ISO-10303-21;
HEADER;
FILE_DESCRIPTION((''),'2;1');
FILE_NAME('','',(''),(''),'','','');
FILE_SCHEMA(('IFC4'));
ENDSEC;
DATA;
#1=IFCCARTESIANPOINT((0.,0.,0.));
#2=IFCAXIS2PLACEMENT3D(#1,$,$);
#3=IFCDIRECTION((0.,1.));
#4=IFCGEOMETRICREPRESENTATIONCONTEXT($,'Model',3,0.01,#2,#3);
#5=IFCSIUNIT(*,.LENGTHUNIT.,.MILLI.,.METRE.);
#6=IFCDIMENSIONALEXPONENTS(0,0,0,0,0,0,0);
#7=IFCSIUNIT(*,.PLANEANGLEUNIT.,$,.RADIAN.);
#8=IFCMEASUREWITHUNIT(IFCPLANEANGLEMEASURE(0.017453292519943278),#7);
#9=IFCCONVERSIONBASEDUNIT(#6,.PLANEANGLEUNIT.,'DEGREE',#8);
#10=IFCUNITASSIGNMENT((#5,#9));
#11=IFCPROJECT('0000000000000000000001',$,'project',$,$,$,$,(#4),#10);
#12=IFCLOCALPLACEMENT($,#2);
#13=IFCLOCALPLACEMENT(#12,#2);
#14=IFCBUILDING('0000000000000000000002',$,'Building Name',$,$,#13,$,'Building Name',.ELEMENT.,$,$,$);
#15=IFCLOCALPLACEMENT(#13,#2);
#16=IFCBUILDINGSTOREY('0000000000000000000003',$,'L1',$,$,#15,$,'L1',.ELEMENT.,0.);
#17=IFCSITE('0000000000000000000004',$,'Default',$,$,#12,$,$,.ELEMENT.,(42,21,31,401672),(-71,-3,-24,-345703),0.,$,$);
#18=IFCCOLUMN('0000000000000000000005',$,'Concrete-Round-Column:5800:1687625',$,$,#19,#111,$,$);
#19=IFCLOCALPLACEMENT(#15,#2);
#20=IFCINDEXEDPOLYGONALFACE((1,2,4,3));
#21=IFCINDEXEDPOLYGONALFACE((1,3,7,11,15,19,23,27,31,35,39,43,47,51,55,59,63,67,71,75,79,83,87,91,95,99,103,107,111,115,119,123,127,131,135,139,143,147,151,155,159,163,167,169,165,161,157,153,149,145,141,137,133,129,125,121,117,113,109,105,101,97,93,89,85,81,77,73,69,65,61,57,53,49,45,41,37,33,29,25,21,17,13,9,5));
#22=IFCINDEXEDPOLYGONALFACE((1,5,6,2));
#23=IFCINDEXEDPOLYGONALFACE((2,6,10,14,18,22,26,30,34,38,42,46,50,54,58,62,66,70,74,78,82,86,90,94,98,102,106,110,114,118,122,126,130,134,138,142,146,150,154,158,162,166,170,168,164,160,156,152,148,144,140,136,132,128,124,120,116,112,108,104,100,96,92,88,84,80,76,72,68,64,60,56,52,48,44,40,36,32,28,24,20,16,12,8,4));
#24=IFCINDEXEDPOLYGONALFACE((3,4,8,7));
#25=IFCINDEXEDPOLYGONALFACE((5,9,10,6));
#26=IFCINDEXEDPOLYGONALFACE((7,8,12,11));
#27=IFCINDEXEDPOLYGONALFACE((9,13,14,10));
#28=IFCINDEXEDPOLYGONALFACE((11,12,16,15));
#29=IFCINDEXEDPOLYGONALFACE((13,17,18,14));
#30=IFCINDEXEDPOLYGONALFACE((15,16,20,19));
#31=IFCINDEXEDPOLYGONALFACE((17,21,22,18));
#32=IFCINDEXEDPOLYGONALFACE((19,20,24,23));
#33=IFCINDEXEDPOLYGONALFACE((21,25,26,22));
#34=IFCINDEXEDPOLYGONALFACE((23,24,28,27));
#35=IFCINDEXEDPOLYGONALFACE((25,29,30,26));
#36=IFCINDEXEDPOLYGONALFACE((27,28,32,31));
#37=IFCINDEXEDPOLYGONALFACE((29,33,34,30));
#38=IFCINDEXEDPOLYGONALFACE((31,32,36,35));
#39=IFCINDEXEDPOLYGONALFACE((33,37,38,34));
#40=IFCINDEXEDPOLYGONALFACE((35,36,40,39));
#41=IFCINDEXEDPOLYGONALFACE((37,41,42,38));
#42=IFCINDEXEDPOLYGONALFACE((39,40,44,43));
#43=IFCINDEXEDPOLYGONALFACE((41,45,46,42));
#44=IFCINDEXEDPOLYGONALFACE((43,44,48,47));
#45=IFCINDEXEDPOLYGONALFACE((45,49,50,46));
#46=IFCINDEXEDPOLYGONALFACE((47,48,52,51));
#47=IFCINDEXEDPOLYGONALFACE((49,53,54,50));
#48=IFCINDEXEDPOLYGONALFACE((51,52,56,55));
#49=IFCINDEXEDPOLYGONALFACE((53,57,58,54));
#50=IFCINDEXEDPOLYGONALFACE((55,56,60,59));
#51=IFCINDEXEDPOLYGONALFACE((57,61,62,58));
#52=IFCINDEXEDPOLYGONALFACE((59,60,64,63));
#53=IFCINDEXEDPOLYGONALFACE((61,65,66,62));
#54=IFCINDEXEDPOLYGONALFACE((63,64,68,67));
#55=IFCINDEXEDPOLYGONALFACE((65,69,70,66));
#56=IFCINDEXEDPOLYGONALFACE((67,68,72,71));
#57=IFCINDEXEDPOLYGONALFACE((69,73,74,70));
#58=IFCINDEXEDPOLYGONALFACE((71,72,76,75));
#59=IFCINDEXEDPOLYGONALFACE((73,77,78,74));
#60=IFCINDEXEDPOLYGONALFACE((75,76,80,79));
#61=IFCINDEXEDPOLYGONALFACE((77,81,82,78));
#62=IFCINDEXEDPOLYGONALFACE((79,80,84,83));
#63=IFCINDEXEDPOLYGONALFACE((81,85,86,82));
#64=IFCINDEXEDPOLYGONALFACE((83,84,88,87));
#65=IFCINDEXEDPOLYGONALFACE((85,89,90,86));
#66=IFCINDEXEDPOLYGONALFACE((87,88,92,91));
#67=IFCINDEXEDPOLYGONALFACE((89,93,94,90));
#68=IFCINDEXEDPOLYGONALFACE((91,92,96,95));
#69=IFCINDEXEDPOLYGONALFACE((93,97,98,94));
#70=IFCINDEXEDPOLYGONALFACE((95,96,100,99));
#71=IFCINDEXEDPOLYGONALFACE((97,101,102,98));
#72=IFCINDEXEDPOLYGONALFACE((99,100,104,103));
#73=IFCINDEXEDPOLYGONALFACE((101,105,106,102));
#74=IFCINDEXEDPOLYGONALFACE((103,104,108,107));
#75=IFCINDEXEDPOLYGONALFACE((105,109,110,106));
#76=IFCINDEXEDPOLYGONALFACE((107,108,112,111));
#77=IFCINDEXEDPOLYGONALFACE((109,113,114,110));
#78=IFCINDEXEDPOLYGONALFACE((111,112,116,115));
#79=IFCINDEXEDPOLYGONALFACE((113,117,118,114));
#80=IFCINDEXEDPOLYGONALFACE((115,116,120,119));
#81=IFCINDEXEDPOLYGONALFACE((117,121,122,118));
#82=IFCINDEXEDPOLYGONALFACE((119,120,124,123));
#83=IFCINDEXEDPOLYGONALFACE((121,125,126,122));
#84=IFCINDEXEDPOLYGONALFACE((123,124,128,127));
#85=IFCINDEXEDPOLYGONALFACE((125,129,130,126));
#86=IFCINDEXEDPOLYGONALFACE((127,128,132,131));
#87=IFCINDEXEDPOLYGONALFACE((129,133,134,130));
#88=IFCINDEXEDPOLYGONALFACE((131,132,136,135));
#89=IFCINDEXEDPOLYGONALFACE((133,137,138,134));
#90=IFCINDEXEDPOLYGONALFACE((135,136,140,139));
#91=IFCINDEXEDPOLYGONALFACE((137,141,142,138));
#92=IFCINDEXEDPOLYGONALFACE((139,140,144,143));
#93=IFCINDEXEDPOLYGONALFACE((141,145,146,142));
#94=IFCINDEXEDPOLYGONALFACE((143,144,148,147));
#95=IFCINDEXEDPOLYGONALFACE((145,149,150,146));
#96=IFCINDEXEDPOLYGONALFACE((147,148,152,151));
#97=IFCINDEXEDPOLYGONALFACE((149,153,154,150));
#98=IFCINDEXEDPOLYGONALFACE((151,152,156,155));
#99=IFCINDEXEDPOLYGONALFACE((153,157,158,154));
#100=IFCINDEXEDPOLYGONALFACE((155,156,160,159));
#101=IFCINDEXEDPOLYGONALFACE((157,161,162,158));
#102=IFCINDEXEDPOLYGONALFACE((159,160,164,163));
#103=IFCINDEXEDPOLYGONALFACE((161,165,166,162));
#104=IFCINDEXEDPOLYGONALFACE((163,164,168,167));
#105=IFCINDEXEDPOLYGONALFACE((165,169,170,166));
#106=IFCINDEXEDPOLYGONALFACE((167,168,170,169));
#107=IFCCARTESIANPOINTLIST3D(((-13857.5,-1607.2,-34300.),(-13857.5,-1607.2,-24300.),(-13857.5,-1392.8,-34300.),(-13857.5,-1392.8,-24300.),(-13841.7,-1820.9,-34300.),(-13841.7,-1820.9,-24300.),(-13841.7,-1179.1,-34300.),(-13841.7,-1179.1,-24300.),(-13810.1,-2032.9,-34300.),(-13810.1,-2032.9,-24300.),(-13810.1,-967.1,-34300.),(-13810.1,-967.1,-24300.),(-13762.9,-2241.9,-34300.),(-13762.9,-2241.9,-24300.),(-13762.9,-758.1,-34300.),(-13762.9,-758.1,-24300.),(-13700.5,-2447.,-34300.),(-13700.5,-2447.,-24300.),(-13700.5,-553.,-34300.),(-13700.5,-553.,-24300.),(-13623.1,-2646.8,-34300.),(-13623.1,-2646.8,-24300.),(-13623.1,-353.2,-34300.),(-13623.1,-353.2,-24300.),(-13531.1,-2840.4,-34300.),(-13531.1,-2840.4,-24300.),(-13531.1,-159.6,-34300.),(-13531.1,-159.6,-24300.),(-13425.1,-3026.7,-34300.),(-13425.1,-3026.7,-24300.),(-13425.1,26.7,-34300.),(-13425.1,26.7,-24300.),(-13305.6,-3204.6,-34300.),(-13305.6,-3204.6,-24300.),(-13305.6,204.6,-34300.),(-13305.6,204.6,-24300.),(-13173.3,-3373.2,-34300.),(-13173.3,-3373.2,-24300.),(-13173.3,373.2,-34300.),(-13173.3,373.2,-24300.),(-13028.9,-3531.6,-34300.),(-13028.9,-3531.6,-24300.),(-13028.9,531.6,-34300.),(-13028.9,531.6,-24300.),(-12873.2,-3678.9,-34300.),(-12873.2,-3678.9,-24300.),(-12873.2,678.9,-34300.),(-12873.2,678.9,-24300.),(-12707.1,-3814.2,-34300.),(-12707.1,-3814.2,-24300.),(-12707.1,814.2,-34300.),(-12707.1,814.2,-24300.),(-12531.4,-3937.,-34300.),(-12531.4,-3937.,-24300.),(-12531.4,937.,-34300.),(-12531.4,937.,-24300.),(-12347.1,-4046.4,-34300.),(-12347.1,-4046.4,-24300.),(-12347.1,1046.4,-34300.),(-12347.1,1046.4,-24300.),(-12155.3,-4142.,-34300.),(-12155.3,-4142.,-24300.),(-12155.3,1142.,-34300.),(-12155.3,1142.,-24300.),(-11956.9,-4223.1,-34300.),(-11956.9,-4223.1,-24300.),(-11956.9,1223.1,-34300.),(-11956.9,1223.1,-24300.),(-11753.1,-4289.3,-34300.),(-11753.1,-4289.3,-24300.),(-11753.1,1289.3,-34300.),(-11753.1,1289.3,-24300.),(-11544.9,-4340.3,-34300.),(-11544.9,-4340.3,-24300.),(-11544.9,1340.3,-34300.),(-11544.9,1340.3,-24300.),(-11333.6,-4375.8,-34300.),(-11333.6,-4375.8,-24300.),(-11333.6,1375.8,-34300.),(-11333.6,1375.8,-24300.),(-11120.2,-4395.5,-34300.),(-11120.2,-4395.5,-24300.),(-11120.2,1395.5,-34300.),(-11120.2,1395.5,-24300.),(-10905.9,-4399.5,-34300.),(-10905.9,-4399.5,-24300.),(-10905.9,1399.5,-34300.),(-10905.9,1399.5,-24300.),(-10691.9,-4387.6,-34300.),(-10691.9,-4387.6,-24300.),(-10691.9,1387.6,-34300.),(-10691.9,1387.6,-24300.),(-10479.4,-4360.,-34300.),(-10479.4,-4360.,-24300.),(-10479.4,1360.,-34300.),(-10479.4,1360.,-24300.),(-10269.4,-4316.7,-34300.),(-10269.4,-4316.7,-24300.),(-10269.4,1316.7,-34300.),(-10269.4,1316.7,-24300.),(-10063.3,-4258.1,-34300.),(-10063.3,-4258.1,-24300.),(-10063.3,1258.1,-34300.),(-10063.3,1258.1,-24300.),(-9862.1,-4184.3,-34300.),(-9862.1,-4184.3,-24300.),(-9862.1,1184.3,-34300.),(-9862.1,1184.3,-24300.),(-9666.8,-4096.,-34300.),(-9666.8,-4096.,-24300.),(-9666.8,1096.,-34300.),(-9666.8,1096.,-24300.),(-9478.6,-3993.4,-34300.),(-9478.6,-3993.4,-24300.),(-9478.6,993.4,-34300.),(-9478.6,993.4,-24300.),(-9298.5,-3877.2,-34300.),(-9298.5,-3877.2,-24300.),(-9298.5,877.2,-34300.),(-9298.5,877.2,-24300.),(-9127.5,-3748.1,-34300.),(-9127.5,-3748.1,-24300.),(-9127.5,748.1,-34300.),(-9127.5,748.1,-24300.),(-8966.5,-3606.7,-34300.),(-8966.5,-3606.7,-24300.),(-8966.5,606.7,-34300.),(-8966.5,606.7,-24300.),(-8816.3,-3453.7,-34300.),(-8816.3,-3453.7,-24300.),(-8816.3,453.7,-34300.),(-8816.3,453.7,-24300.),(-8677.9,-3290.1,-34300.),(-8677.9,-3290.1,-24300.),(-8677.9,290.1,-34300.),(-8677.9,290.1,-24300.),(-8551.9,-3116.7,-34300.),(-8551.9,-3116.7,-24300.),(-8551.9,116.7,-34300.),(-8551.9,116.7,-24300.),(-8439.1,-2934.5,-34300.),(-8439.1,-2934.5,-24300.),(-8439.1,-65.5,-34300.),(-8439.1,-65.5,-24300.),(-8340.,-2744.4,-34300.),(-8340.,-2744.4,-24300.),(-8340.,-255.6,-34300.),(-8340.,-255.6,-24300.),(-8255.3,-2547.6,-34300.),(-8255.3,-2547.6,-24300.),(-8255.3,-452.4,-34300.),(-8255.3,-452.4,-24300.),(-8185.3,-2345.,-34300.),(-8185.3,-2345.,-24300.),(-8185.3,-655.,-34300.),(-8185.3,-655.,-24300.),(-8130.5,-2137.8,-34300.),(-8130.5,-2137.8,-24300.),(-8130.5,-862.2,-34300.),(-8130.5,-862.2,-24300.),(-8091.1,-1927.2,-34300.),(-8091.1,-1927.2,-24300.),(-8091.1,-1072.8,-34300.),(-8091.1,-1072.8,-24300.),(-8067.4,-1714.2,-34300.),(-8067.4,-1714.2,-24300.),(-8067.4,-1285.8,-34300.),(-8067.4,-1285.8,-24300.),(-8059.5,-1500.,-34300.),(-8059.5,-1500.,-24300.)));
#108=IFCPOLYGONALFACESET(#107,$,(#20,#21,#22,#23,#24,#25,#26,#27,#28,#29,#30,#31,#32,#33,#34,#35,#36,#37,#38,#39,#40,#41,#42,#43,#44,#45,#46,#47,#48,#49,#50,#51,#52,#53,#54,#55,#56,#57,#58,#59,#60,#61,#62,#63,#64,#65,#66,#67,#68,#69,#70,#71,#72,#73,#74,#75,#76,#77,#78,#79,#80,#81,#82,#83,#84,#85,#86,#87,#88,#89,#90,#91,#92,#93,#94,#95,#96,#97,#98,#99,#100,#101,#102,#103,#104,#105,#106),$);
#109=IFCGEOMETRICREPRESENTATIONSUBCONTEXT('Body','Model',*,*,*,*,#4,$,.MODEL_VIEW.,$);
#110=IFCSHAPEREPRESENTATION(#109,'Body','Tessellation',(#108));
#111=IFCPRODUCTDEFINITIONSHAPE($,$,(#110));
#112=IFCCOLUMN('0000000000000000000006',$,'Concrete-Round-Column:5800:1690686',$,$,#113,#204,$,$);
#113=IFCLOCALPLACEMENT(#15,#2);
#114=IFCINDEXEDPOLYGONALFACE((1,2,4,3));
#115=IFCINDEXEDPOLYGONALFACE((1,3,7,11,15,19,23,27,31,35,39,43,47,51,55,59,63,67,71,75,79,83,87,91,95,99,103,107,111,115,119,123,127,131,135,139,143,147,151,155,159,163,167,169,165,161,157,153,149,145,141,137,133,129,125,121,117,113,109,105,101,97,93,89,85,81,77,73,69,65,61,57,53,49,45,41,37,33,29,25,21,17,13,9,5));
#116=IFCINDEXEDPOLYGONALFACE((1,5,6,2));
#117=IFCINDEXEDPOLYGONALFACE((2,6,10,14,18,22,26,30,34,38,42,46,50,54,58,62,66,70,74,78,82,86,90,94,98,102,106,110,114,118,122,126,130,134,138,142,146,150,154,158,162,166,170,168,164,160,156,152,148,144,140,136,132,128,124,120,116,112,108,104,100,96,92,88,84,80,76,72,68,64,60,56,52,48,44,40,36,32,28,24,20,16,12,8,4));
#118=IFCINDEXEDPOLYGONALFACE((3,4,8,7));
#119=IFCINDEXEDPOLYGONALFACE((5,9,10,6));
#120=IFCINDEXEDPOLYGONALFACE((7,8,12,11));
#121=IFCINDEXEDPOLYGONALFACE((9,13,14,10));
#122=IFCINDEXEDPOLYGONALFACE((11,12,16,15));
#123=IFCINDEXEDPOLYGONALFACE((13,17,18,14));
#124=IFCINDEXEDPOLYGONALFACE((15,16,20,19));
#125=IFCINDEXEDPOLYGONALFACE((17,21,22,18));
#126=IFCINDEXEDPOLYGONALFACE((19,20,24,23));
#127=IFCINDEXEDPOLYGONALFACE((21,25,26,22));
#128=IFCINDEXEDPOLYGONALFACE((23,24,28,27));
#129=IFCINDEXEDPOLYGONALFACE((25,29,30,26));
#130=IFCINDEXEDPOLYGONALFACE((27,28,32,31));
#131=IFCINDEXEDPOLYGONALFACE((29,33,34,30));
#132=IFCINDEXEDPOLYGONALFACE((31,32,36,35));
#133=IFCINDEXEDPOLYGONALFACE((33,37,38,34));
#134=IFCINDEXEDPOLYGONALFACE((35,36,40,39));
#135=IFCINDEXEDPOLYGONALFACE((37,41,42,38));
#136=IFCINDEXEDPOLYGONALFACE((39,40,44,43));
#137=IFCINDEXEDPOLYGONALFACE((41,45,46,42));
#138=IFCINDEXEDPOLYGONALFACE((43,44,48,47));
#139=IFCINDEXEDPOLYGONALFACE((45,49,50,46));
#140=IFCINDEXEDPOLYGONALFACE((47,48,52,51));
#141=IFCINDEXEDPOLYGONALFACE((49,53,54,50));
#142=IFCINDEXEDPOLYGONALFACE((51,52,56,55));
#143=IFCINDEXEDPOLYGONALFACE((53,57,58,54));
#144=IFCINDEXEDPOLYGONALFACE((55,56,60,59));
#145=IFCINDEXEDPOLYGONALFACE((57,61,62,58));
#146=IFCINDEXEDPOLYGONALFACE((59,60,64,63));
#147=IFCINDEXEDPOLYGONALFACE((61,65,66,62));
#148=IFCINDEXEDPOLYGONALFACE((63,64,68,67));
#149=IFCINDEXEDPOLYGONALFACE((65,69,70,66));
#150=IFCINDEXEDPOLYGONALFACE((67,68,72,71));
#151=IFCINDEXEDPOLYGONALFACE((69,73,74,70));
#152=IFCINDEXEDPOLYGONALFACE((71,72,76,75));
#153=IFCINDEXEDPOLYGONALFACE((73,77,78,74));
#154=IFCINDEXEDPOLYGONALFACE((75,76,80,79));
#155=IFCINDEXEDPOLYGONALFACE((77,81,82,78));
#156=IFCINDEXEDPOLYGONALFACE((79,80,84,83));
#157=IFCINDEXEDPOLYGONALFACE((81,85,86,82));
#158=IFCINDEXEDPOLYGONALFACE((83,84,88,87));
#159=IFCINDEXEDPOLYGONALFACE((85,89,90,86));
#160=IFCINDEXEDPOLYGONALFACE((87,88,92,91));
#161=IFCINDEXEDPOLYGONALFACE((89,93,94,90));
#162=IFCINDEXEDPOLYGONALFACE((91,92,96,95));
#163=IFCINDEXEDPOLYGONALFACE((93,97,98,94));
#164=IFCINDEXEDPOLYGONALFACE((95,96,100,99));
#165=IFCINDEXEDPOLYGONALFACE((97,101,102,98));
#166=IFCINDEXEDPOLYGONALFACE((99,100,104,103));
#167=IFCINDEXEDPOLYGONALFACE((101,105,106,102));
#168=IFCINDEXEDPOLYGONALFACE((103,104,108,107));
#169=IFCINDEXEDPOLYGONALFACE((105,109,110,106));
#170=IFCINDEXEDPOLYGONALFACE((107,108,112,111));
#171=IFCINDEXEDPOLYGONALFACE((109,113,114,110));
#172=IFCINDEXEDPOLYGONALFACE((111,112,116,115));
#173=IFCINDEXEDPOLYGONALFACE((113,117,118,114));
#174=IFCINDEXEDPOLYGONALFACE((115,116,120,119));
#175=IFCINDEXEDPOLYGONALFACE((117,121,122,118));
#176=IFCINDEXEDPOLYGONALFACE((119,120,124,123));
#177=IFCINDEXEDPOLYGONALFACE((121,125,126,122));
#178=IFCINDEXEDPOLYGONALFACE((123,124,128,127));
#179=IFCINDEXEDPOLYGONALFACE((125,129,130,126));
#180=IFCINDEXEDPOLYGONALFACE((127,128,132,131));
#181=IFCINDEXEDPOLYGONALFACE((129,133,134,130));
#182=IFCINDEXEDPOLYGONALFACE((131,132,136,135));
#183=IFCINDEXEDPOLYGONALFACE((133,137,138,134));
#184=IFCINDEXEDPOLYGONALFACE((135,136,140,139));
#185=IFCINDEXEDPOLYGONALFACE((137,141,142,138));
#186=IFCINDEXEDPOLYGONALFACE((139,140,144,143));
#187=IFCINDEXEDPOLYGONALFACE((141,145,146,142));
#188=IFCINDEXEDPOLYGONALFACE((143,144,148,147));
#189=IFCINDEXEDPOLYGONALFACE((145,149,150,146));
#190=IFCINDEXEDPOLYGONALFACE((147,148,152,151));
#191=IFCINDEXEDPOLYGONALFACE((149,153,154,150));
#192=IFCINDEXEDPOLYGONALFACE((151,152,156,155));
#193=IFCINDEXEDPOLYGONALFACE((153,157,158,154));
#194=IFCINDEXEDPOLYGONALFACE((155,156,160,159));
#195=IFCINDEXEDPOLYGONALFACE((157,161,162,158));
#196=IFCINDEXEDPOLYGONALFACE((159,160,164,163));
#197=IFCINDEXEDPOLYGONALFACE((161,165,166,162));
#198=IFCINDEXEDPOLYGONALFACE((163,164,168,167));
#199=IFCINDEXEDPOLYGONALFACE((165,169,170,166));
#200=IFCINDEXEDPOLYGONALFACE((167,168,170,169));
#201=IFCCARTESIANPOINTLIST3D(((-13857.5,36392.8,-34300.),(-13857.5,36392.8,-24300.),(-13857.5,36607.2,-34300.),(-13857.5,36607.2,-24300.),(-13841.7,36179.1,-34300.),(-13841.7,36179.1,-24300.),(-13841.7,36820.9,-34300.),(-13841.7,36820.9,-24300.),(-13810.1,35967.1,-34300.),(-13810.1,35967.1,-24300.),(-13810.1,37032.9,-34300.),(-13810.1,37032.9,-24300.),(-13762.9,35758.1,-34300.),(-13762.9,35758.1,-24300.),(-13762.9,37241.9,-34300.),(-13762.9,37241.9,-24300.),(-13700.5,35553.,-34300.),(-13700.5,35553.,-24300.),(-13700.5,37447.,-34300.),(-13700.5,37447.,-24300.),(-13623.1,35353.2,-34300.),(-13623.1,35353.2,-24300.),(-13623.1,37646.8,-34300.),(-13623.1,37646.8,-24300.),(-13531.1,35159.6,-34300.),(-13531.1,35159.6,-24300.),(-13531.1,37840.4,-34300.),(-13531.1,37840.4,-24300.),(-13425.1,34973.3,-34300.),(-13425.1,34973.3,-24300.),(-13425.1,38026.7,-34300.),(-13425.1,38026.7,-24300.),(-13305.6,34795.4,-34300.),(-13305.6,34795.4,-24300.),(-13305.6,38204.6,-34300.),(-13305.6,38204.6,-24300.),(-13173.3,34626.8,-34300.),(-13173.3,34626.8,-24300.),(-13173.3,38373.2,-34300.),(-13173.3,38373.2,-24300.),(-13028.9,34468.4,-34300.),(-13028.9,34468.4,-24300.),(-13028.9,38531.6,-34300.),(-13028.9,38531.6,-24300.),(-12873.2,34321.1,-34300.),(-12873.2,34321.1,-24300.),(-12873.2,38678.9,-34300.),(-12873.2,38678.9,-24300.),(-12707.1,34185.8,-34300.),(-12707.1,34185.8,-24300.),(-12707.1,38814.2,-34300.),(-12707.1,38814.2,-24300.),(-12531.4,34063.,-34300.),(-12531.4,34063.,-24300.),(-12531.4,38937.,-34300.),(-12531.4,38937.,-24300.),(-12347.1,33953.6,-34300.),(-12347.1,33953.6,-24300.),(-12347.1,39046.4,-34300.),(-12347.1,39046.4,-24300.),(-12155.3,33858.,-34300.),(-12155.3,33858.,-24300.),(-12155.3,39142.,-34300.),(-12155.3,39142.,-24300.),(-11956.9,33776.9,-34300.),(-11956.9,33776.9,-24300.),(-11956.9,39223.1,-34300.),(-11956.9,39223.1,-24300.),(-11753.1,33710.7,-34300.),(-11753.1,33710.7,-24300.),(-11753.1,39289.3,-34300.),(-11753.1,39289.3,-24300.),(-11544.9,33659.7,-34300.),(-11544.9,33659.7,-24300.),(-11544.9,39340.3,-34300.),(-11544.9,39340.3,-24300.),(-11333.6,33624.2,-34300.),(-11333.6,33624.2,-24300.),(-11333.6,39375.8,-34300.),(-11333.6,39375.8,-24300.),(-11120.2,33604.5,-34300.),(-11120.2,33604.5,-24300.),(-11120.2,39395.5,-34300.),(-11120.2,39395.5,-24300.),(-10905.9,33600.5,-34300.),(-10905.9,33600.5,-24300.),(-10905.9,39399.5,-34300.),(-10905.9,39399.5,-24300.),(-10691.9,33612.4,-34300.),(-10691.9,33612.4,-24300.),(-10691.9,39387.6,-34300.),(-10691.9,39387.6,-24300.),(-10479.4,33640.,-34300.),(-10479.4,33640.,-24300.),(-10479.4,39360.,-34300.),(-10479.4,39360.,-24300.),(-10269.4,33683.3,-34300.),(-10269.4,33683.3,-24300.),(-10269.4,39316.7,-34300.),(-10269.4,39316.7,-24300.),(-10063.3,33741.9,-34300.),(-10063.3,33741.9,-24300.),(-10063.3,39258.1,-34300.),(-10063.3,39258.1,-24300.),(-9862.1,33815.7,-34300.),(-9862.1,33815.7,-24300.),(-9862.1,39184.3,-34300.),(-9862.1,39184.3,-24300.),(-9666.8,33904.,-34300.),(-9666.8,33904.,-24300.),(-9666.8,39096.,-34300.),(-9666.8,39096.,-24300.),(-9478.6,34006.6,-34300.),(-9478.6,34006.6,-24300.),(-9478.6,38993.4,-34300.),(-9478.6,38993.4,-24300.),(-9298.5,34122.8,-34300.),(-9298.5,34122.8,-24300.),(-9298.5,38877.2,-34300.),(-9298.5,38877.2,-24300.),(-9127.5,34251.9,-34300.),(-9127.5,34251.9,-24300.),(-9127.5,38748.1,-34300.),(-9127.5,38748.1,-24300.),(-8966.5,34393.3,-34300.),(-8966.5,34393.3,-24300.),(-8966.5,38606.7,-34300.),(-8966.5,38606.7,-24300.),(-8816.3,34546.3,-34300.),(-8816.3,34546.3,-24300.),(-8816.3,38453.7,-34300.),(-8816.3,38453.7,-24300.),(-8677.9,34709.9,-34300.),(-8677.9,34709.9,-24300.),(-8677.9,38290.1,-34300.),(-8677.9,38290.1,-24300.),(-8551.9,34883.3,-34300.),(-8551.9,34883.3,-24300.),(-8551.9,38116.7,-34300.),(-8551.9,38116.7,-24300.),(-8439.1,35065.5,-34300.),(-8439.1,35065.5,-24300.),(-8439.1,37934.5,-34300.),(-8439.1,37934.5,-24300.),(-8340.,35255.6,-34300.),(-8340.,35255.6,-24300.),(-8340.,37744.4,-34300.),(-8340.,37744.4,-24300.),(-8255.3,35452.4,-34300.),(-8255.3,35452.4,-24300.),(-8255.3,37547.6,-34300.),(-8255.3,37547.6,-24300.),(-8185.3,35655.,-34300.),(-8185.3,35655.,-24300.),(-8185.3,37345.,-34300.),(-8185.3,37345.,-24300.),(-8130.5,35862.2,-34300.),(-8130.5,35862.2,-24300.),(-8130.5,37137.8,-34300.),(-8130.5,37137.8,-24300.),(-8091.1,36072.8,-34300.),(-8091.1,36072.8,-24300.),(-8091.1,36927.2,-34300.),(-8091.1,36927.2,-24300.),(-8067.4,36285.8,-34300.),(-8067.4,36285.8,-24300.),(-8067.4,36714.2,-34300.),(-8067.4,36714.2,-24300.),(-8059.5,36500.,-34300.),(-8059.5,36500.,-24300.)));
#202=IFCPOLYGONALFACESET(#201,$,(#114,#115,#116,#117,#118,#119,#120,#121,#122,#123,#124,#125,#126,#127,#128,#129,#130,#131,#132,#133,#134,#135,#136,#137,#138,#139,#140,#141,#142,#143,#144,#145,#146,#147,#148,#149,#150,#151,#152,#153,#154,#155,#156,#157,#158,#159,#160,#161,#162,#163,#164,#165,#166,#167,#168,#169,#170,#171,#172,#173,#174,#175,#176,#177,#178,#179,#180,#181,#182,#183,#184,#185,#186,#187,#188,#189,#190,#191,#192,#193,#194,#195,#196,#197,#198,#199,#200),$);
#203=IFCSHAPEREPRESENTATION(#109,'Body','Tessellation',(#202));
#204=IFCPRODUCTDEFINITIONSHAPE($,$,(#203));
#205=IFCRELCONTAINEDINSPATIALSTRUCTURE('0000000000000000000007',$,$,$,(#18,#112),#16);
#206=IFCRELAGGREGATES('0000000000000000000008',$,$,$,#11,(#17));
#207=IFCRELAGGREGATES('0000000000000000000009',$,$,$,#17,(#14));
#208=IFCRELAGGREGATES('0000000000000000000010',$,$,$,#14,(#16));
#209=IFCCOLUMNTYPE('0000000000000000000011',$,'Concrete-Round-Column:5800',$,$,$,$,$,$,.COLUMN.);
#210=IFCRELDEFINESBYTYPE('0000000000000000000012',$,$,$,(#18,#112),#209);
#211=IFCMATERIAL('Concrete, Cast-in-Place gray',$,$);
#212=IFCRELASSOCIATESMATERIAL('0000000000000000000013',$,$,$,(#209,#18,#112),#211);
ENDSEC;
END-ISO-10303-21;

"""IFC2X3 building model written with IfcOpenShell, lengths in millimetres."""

from ifc_helpers import new_model, entity, si_unit, converted_unit, direction, frame, frame_2d, origin, place, context, subcontext, project, spatial, circle, extrude, source, transform, mapped, material, type_object, type_shapes, element, save


model = new_model("IFC2X3")

# Units and contexts
model_context = context("Model", 3, precision=0.01, world=origin(), true_north=direction((0.0, 1.0)))
body_context = subcontext(model_context, "Body", "Model", "MODEL_VIEW")
ifc_project = project(units=[si_unit("LENGTHUNIT", "METRE", prefix="MILLI"), converted_unit("PLANEANGLEUNIT", "DEGREE", entity("IfcPlaneAngleMeasure", 0.017453292519943278), si_unit("PLANEANGLEUNIT", "RADIAN"), dimensions=[0, 0, 0, 0, 0, 0, 0])], contexts=[model_context])

# Site, building, storey
site_placement = place(None, origin())
site = spatial("IfcSite", under=ifc_project, at=site_placement, Name="Default", CompositionType="ELEMENT", RefLatitude=(42, 21, 31, 401672), RefLongitude=(-71, -3, -24, -345703), RefElevation=0.0)
building_placement = place(site_placement, origin())
building = spatial("IfcBuilding", under=site, at=building_placement, Name="Building Name", LongName="Building Name", CompositionType="ELEMENT")
storey_placement = place(building_placement, origin())
storey = spatial("IfcBuildingStorey", under=building, at=storey_placement, Name="L1", LongName="L1", CompositionType="ELEMENT", Elevation=0.0)

# Columns
ifc_material_1 = material(Name="Concrete, Cast-in-Place gray")
column_type_1 = type_object("IfcColumnType", Name="Concrete-Round-Column:5800", PredefinedType="COLUMN", material=ifc_material_1)
shared_shape_1 = source(origin(), body_context, "Body", "SweptSolid", [
    extrude(circle(Radius=2900.0, at=frame_2d((0.0, 0.0), x_axis=(1.0, 0.0))), frame((0.0, 0.0, -34300.0)), (0.0, 0.0, 1.0), 10000.0),
])
type_shapes(column_type_1, [shared_shape_1])
for number, where, name in (
    (1, (-10959.5, -1500.0, 0.0), "Concrete-Round-Column:5800:1687625"),
    (2, (-10959.5, 36500.0, 0.0), "Concrete-Round-Column:5800:1690686"),
):
    element("IfcColumn", number, at=place(storey_placement, frame(where)), inside=storey, type_object=column_type_1, material=ifc_material_1, Name=name, context=body_context, shape_type="MappedRepresentation", body=[
        mapped(shared_shape_1, transform((0.0, 0.0, 0.0), scale=1.0)),
    ])

save(model, "model.ifc")
